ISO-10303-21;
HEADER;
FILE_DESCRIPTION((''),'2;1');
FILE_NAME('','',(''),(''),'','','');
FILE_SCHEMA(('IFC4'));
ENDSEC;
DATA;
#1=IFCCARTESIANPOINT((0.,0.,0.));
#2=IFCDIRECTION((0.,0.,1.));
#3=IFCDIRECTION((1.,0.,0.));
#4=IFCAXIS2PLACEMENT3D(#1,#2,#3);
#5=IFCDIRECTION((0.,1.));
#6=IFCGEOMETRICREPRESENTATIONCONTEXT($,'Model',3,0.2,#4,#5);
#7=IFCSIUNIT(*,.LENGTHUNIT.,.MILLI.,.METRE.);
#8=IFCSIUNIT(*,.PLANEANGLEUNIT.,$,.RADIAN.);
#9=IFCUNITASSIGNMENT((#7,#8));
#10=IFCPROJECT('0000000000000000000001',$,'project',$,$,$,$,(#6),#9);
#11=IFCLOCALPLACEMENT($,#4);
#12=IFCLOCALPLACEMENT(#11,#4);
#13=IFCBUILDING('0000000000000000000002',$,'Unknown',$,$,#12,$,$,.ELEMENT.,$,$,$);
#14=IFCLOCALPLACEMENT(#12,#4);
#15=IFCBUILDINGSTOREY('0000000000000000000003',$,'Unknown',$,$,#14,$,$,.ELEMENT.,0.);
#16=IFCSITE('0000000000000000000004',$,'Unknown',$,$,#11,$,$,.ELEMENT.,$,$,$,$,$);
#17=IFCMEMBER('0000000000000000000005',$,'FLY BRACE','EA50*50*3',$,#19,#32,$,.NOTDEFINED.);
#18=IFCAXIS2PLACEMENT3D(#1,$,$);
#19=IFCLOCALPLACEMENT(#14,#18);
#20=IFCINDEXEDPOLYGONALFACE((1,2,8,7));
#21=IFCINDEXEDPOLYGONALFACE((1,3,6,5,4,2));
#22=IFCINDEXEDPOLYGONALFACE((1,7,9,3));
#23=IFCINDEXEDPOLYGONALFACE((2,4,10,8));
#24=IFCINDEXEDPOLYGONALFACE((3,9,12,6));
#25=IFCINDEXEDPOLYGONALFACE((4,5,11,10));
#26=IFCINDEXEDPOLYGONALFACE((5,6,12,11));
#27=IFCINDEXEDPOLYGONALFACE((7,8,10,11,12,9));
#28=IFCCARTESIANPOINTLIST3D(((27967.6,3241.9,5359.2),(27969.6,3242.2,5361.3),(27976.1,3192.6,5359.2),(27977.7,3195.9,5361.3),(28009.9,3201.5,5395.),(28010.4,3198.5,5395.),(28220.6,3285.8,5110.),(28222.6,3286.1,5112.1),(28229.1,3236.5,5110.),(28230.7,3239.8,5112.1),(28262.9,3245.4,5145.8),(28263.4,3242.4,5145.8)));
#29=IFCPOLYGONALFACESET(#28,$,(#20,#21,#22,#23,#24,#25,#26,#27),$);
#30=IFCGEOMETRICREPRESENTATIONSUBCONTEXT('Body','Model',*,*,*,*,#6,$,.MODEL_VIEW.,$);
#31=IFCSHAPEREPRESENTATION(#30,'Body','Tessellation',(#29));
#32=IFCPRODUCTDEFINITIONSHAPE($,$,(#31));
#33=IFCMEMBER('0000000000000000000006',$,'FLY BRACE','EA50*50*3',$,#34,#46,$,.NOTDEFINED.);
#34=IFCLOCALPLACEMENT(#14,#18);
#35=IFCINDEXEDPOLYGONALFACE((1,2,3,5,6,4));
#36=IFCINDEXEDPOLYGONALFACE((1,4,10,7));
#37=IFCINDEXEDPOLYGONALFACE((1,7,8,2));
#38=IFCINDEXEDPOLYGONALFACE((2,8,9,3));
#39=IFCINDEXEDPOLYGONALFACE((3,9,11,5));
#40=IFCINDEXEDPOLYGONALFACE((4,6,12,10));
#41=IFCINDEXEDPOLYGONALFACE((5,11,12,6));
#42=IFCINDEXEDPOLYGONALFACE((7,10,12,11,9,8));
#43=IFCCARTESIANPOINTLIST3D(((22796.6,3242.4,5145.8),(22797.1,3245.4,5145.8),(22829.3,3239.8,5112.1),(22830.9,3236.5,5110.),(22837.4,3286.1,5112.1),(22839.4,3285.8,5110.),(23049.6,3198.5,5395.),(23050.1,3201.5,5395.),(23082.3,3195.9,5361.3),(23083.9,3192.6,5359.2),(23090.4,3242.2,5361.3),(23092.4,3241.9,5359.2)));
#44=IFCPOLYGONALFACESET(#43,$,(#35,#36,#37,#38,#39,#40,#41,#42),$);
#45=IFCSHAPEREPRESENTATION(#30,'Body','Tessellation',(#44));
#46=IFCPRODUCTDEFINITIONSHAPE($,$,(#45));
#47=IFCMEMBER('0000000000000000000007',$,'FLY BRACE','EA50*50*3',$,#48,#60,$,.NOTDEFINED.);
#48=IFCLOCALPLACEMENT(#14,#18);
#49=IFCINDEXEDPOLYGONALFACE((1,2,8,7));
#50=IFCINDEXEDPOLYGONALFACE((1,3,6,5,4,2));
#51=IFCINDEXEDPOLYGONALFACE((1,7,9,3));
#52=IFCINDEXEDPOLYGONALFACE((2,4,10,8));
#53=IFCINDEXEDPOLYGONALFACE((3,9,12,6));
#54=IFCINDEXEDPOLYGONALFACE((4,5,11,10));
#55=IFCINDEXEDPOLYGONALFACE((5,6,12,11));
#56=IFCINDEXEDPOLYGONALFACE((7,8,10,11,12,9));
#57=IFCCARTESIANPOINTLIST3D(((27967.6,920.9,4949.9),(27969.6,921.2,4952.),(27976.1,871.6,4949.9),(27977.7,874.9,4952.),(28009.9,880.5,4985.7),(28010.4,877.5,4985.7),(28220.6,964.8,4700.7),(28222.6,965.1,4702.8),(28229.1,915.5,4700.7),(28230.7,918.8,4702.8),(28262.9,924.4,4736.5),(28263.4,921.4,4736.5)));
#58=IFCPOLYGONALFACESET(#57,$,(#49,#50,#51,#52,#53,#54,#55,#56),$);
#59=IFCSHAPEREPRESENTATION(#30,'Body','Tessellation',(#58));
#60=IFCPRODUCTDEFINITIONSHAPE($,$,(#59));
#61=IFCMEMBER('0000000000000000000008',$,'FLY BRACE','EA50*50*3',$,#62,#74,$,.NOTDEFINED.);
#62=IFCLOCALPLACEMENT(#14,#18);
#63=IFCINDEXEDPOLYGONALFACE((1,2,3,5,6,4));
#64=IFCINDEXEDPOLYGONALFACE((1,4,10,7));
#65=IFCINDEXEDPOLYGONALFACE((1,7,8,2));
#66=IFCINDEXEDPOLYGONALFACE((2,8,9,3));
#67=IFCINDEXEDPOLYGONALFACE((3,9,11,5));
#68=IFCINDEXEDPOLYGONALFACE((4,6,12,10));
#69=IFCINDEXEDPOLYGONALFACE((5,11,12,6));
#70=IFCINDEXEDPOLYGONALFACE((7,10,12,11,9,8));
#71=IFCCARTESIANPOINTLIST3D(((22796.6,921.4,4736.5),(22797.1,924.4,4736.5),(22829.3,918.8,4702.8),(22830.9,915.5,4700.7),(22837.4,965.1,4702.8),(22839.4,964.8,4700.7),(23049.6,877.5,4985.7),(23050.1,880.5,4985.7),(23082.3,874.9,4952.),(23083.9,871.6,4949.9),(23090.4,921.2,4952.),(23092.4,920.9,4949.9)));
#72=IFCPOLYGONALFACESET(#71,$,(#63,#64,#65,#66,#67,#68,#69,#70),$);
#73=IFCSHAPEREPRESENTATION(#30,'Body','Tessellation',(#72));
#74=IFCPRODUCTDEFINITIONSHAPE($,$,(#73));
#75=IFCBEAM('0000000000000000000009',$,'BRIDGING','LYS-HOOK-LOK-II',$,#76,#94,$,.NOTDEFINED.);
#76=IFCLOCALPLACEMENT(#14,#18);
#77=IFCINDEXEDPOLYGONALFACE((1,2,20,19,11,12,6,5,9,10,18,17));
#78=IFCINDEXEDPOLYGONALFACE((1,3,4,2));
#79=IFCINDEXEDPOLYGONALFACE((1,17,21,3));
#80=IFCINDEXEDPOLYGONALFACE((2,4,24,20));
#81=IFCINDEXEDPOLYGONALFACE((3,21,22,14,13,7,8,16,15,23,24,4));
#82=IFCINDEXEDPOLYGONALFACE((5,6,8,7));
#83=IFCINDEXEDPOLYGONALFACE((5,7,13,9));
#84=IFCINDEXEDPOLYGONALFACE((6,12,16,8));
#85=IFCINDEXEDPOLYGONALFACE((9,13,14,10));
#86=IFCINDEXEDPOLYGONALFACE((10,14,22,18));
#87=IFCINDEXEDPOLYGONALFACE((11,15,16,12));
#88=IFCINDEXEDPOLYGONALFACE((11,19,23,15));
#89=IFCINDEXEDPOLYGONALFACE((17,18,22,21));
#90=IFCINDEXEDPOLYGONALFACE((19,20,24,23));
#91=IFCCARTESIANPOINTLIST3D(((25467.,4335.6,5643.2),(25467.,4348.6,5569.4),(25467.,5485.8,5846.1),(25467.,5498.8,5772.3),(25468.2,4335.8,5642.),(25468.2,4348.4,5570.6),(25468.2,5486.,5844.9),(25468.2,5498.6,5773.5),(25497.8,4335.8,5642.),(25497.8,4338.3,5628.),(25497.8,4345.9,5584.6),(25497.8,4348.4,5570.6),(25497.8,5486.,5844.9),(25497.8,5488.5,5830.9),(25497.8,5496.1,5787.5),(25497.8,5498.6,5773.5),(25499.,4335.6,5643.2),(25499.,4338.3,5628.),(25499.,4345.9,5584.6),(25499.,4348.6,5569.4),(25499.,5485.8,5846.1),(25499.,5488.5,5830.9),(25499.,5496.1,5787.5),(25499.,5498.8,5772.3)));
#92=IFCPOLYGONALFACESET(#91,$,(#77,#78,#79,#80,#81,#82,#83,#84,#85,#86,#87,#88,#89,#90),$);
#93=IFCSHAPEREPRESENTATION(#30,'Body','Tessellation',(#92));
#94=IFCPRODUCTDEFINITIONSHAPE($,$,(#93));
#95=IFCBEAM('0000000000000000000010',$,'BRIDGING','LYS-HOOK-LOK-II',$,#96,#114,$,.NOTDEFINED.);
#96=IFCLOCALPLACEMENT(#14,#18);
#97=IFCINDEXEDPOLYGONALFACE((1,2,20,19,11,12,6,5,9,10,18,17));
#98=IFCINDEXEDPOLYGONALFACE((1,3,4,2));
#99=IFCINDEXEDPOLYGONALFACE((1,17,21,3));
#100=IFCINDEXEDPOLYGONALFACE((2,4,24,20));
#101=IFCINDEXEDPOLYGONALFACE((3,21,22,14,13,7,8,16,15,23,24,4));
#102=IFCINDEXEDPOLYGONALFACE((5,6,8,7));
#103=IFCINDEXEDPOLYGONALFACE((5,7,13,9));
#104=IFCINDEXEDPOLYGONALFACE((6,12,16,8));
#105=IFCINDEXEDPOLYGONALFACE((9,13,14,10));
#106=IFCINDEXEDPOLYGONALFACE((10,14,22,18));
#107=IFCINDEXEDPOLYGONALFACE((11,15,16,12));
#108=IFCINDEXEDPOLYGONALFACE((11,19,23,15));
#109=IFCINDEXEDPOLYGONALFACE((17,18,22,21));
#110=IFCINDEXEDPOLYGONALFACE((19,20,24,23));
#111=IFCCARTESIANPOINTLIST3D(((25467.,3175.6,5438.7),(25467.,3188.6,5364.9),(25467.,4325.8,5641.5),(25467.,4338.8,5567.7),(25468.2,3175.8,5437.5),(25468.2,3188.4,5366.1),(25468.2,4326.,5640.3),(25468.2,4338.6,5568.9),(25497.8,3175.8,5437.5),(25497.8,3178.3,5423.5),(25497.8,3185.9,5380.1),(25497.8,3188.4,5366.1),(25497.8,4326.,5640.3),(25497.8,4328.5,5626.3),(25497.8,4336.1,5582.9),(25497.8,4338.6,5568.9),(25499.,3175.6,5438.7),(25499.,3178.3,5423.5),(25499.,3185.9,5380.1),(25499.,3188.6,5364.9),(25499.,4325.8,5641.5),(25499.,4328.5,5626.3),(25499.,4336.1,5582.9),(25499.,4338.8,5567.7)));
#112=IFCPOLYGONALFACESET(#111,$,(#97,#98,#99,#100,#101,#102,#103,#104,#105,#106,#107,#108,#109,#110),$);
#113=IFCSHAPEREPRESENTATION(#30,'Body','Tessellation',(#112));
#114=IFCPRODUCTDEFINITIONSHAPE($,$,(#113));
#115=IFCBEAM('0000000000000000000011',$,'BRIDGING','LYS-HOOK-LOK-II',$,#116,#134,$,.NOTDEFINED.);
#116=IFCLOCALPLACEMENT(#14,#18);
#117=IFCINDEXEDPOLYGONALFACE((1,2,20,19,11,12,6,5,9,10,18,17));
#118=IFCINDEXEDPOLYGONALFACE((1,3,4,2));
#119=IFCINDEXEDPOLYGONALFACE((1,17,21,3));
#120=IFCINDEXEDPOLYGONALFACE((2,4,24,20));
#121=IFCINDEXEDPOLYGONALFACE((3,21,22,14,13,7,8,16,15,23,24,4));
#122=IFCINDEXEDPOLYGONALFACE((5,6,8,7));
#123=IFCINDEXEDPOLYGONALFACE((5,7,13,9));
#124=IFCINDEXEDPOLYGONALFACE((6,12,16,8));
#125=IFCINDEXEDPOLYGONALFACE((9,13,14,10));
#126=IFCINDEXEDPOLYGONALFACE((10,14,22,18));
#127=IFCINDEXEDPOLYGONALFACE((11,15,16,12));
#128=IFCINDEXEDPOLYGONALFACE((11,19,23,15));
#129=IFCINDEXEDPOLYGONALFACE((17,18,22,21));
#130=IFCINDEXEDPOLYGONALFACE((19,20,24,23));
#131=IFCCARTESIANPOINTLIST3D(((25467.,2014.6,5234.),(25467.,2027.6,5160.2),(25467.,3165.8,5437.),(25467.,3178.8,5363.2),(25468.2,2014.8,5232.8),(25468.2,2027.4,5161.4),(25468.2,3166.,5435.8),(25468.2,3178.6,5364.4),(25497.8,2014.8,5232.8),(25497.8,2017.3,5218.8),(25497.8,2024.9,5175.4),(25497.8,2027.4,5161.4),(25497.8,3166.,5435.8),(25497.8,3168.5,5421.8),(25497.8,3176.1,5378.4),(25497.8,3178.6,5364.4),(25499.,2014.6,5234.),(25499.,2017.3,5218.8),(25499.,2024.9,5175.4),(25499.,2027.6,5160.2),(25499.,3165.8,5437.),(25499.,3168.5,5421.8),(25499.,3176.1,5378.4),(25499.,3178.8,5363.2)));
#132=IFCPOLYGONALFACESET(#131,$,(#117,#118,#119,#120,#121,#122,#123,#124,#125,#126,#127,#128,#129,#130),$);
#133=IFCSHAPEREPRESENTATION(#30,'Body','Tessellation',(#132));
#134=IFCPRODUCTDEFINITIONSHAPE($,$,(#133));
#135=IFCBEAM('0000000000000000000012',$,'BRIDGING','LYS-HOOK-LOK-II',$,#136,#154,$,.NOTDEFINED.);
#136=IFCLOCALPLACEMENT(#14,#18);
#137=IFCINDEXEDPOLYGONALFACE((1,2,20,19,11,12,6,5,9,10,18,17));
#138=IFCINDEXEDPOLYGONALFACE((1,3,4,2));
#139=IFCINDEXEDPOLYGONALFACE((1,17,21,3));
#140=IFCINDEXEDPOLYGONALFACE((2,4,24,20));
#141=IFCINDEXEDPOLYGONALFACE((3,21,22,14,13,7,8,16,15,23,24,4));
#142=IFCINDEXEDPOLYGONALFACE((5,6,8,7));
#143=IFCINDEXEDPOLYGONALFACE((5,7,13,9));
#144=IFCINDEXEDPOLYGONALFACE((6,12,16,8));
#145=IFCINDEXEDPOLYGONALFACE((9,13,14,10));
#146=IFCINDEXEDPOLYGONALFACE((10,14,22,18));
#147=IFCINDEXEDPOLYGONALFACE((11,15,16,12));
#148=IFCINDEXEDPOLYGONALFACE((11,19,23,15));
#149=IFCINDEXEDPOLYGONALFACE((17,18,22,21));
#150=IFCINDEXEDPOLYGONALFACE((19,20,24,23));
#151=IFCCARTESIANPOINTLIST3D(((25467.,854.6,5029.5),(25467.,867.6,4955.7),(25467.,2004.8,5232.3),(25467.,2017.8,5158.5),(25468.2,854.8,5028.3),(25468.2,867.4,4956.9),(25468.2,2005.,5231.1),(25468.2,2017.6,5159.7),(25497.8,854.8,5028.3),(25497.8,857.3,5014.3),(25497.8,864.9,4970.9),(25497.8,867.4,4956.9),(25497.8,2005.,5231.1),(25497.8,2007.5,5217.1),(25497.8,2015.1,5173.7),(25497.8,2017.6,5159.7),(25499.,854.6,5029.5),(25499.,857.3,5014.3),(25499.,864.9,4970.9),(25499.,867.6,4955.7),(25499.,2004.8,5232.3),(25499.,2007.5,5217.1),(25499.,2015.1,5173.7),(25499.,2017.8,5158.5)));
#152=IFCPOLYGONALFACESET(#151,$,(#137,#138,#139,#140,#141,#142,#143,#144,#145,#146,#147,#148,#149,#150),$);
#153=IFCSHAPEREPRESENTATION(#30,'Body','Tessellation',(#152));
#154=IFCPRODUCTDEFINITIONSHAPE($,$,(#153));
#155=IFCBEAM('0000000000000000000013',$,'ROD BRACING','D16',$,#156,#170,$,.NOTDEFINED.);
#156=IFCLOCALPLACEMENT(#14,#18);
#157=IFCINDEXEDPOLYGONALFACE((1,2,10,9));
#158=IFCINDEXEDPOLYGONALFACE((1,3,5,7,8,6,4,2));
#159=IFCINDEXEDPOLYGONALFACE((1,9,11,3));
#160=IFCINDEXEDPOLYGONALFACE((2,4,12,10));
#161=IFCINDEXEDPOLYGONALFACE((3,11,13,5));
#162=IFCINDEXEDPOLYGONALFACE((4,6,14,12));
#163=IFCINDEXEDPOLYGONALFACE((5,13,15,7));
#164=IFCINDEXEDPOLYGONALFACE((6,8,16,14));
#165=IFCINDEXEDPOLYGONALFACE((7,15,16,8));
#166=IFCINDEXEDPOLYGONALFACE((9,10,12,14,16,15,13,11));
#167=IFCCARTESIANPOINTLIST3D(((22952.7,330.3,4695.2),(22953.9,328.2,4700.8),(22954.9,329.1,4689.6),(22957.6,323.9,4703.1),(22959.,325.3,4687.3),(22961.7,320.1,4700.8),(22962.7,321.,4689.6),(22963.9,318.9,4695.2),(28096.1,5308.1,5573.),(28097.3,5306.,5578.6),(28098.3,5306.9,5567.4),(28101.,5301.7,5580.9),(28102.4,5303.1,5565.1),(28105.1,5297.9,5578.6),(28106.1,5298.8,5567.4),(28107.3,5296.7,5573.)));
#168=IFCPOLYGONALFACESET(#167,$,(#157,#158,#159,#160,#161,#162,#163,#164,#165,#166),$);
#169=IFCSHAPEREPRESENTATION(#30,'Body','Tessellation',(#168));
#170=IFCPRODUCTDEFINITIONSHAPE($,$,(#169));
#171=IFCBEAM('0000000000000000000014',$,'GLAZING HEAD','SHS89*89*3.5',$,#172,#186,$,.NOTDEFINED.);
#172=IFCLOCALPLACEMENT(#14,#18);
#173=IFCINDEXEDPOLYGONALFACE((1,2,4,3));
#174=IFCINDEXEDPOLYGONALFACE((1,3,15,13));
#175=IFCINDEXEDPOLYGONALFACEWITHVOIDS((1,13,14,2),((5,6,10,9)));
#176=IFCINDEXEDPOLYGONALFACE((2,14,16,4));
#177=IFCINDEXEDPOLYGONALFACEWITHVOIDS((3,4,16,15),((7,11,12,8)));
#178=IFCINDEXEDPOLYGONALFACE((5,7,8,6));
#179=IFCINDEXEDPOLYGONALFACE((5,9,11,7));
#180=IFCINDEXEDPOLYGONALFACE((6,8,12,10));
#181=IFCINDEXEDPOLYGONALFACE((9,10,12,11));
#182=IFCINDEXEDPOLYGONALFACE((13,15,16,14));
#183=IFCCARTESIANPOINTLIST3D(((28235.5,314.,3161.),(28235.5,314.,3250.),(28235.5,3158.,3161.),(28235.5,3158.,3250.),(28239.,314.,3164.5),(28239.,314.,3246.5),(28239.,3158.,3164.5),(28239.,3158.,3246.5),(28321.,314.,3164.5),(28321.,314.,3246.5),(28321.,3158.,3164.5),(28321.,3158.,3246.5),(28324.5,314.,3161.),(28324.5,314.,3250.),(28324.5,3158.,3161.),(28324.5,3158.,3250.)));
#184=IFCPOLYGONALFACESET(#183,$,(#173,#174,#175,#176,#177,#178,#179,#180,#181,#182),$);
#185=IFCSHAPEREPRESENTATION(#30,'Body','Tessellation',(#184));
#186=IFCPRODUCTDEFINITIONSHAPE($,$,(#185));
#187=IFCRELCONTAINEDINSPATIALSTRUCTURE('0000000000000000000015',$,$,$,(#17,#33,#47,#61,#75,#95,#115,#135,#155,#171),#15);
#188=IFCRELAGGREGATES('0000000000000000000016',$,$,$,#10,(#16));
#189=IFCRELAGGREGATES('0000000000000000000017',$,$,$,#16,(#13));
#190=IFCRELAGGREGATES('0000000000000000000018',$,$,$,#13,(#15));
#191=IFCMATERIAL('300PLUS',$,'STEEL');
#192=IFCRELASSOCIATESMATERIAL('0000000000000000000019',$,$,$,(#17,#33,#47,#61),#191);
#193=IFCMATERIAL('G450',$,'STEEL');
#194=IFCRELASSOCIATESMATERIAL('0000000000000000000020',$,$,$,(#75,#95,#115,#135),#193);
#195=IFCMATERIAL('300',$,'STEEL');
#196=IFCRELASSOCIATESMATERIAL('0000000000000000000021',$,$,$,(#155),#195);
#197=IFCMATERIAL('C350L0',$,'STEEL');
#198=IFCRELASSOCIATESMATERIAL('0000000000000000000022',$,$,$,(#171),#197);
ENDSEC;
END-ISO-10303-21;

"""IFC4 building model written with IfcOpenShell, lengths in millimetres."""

from ifc_helpers import new_model, si_unit, direction, frame, origin_with_axes, place, context, subcontext, project, spatial, line, indexed_curve, outline, extrude, material, element, save


model = new_model("IFC4")

# Units and contexts
model_context = context("Model", 3, precision=0.2, world=origin_with_axes(), true_north=direction((0.0, 1.0)))
body_context = subcontext(model_context, "Body", "Model", "MODEL_VIEW")
ifc_project = project(units=[si_unit("LENGTHUNIT", "METRE", prefix="MILLI"), si_unit("PLANEANGLEUNIT", "RADIAN")], contexts=[model_context])

# Site, building, storey
site_placement = place(None, origin_with_axes())
site = spatial("IfcSite", under=ifc_project, at=site_placement, Name="Unknown", CompositionType="ELEMENT")
building_placement = place(site_placement, origin_with_axes())
building = spatial("IfcBuilding", under=site, at=building_placement, Name="Unknown", CompositionType="ELEMENT")
storey_placement = place(building_placement, origin_with_axes())
storey = spatial("IfcBuildingStorey", under=building, at=storey_placement, Name="Unknown", CompositionType="ELEMENT", Elevation=0.0)

# Members
ifc_material_1 = material(Name="300PLUS", Category="STEEL")
for number, where, z_axis, x_axis, name in (
    (1, (27989.0, 3220.2, 5377.1), (0.686182, 0.119065, 0.71762), (0.707055, 0.122687, -0.696435), "FLY BRACE"),
    (2, (23071.0, 3220.2, 5377.1), (0.170963, 0.985277, 0.0), (-0.707055, 0.122687, -0.696435), "FLY BRACE"),
    (3, (27989.0, 899.2, 4967.8), (0.686182, 0.119065, 0.71762), (0.707055, 0.122687, -0.696435), "FLY BRACE"),
    (4, (23071.0, 899.2, 4967.8), (0.170963, 0.985277, 0.0), (-0.707055, 0.122687, -0.696435), "FLY BRACE"),
):
    element("IfcMember", number, at=place(storey_placement, frame(where, z_axis=z_axis, x_axis=x_axis)), inside=storey, material=ifc_material_1, Name=name, Description="EA50*50*3", PredefinedType="NOTDEFINED", context=body_context, shape_type="SolidModel", body=[
        extrude(outline(indexed_curve([(-25.0, -25.0), (25.0, -25.0), (25.0, -22.0), (-22.0, -22.0), (-22.0, 25.0), (-25.0, 25.0)], segments=[line(1, 2, 3, 4, 5, 6, 1)])), frame((0.0, 0.0, 0.0), z_axis=(-1.0, 0.0, 0.0), x_axis=(0.0, 0.0, 1.0)), (0.0, 0.0, -1.0), 357.8),
    ])

# Beams
ifc_material_2 = material(Name="G450", Category="STEEL")
beam_1_placement = place(storey_placement, frame((25483.0, 4342.1, 5606.3), z_axis=(1.0, 0.0, 0.0), x_axis=(0.0, 0.984795, 0.173722)))
element("IfcBeam", 5, at=beam_1_placement, inside=storey, material=ifc_material_2, Name="BRIDGING", Description="LYS-HOOK-LOK-II", PredefinedType="NOTDEFINED", context=body_context, shape_type="SolidModel", body=[
    extrude(outline(indexed_curve([(16.0, -37.5), (16.0, -22.0), (14.8, -22.0), (14.8, -36.3), (-14.8, -36.3), (-14.8, 36.3), (14.8, 36.3), (14.8, 22.0), (16.0, 22.0), (16.0, 37.5), (-16.0, 37.5), (-16.0, -37.5)], segments=[line(1, 2, 3, 4, 5, 6, 7, 8, 9, 10, 11, 12, 1)])), frame((0.0, 0.0, 0.0), z_axis=(-1.0, 0.0, 0.0), x_axis=(0.0, 0.0, 1.0)), (0.0, 0.0, -1.0), 1168.0),
])
beam_2_placement = place(storey_placement, frame((25483.0, 3182.1, 5401.8), z_axis=(1.0, 0.0, 0.0), x_axis=(0.0, 0.984809, 0.173639)))
element("IfcBeam", 6, at=beam_2_placement, inside=storey, material=ifc_material_2, Name="BRIDGING", Description="LYS-HOOK-LOK-II", PredefinedType="NOTDEFINED", context=body_context, shape_type="SolidModel", body=[
    extrude(outline(indexed_curve([(16.0, -37.5), (16.0, -22.0), (14.8, -22.0), (14.8, -36.3), (-14.8, -36.3), (-14.8, 36.3), (14.8, 36.3), (14.8, 22.0), (16.0, 22.0), (16.0, 37.5), (-16.0, 37.5), (-16.0, -37.5)], segments=[line(1, 2, 3, 4, 5, 6, 7, 8, 9, 10, 11, 12, 1)])), frame((0.0, 0.0, 0.0), z_axis=(-1.0, 0.0, 0.0), x_axis=(0.0, 0.0, 1.0)), (0.0, 0.0, -1.0), 1167.9),
])
beam_3_placement = place(storey_placement, frame((25483.0, 2021.1, 5197.1), z_axis=(1.0, 0.0, 0.0), x_axis=(0.0, 0.984806, 0.173658)))
element("IfcBeam", 7, at=beam_3_placement, inside=storey, material=ifc_material_2, Name="BRIDGING", Description="LYS-HOOK-LOK-II", PredefinedType="NOTDEFINED", context=body_context, shape_type="SolidModel", body=[
    extrude(outline(indexed_curve([(16.0, -37.5), (16.0, -22.0), (14.8, -22.0), (14.8, -36.3), (-14.8, -36.3), (-14.8, 36.3), (14.8, 36.3), (14.8, 22.0), (16.0, 22.0), (16.0, 37.5), (-16.0, 37.5), (-16.0, -37.5)], segments=[line(1, 2, 3, 4, 5, 6, 7, 8, 9, 10, 11, 12, 1)])), frame((0.0, 0.0, 0.0), z_axis=(-1.0, 0.0, 0.0), x_axis=(0.0, 0.0, 1.0)), (0.0, 0.0, -1.0), 1169.0),
])
beam_4_placement = place(storey_placement, frame((25483.0, 861.1, 4992.6), z_axis=(1.0, 0.0, 0.0), x_axis=(0.0, 0.984809, 0.173639)))
element("IfcBeam", 8, at=beam_4_placement, inside=storey, material=ifc_material_2, Name="BRIDGING", Description="LYS-HOOK-LOK-II", PredefinedType="NOTDEFINED", context=body_context, shape_type="SolidModel", body=[
    extrude(outline(indexed_curve([(16.0, -37.5), (16.0, -22.0), (14.8, -22.0), (14.8, -36.3), (-14.8, -36.3), (-14.8, 36.3), (14.8, 36.3), (14.8, 22.0), (16.0, 22.0), (16.0, 37.5), (-16.0, 37.5), (-16.0, -37.5)], segments=[line(1, 2, 3, 4, 5, 6, 7, 8, 9, 10, 11, 12, 1)])), frame((0.0, 0.0, 0.0), z_axis=(-1.0, 0.0, 0.0), x_axis=(0.0, 0.0, 1.0)), (0.0, 0.0, -1.0), 1167.9),
])
ifc_material_3 = material(Name="300", Category="STEEL")
beam_5_placement = place(storey_placement, frame((22958.3, 324.6, 4695.2), z_axis=(-0.087469, -0.084653, 0.992564), x_axis=(0.713237, 0.690273, 0.121725)))
element("IfcBeam", 9, at=beam_5_placement, inside=storey, material=ifc_material_3, Name="ROD BRACING", Description="D16", PredefinedType="NOTDEFINED", context=body_context, shape_type="SolidModel", body=[
    extrude(outline(indexed_curve([(8.0, 0.0), (5.7, 5.7), (0.0, 8.0), (-5.7, 5.7), (-8.0, 0.0), (-5.7, -5.7), (0.0, -8.0), (5.7, -5.7)], segments=[line(1, 2, 3, 4, 5, 6, 7, 8, 1)])), frame((0.0, 0.0, 0.0), z_axis=(-1.0, 0.0, 0.0), x_axis=(0.0, 0.0, 1.0)), (0.0, 0.0, -1.0), 7211.4),
])
ifc_material_4 = material(Name="C350L0", Category="STEEL")
beam_6_placement = place(storey_placement, frame((28280.0, 314.0, 3205.5), z_axis=(0.0, 0.0, 1.0), x_axis=(0.0, 1.0, 0.0)))
element("IfcBeam", 10, at=beam_6_placement, inside=storey, material=ifc_material_4, Name="GLAZING HEAD", Description="SHS89*89*3.5", PredefinedType="NOTDEFINED", context=body_context, shape_type="SolidModel", body=[
    extrude(outline(indexed_curve([(-44.5, -44.5), (44.5, -44.5), (44.5, 44.5), (-44.5, 44.5)], segments=[line(1, 2, 3, 4, 1)]), holes=[indexed_curve([(-41.0, -41.0), (-41.0, 41.0), (41.0, 41.0), (41.0, -41.0)], segments=[line(1, 2, 3, 4, 1)])]), frame((0.0, 0.0, 0.0), z_axis=(-1.0, 0.0, 0.0), x_axis=(0.0, 0.0, 1.0)), (0.0, 0.0, -1.0), 2844.0),
])

save(model, "model.ifc")
